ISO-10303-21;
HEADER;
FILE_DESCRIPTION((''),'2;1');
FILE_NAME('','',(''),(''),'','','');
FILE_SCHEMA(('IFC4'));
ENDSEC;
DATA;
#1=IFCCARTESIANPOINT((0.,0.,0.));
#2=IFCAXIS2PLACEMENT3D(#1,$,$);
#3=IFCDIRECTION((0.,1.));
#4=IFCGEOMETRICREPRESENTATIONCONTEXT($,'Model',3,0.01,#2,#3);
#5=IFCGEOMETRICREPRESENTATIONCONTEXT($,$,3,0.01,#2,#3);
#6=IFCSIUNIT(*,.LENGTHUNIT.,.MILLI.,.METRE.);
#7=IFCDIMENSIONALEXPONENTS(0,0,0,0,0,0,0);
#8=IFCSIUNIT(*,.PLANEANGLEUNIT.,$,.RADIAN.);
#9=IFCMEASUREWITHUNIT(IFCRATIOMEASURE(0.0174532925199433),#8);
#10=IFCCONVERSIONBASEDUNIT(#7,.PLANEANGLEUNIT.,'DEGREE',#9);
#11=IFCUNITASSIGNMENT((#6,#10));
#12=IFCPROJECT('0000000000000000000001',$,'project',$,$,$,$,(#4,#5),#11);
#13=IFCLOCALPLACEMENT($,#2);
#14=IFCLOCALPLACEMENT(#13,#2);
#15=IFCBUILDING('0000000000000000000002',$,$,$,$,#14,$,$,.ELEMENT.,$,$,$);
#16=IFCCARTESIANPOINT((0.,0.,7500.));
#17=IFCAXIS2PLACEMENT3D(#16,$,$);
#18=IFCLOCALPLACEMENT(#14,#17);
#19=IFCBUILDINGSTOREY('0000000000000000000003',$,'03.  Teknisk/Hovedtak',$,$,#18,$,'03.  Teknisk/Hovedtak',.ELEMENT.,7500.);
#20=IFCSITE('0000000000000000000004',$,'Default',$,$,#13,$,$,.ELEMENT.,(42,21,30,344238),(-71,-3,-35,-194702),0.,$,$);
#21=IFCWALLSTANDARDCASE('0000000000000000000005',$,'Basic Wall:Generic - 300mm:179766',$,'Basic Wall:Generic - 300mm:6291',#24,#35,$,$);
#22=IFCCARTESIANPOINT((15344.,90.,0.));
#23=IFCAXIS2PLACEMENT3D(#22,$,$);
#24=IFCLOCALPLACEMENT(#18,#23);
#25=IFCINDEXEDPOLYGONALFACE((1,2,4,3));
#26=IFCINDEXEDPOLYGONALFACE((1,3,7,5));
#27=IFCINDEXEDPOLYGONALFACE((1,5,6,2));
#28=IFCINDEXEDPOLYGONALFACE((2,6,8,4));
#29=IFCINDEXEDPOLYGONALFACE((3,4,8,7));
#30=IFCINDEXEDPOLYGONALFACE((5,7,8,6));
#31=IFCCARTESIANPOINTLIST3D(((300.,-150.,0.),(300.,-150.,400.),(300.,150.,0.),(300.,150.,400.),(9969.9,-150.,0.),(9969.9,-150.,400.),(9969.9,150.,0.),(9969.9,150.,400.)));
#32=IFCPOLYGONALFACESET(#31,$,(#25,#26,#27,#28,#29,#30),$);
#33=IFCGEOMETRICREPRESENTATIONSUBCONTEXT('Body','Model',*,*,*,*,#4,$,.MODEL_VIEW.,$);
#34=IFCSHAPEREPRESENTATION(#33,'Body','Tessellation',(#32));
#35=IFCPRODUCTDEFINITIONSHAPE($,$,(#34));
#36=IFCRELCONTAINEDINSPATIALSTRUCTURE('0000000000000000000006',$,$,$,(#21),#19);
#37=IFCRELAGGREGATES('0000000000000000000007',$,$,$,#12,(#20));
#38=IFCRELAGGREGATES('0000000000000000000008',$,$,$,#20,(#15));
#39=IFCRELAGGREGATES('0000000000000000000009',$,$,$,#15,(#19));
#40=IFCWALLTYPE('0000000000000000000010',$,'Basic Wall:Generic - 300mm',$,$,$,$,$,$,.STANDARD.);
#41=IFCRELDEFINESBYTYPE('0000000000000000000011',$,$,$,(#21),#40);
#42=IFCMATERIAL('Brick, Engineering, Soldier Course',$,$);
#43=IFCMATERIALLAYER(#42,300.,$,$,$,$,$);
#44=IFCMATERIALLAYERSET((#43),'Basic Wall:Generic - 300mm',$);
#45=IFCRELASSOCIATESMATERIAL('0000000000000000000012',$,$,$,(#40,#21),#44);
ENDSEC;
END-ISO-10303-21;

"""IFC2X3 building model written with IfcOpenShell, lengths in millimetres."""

from ifc_helpers import new_model, entity, si_unit, converted_unit, direction, frame, frame_2d, origin, place, context, subcontext, project, spatial, rectangle, extrude, clip, halfspace, material, layer, layer_set, layer_usage, type_object, element, save


model = new_model("IFC2X3")

# Units and contexts
model_context = context("Model", 3, precision=0.01, world=origin(), true_north=direction((0.0, 1.0)))
context_of_model = context(None, 3, precision=0.01, world=origin(), true_north=direction((0.0, 1.0)))
body_context = subcontext(model_context, "Body", "Model", "MODEL_VIEW")
ifc_project = project(units=[si_unit("LENGTHUNIT", "METRE", prefix="MILLI"), converted_unit("PLANEANGLEUNIT", "DEGREE", entity("IfcRatioMeasure", 0.0174532925199433), si_unit("PLANEANGLEUNIT", "RADIAN"), dimensions=[0, 0, 0, 0, 0, 0, 0])], contexts=[model_context, context_of_model])

# Site, building, storey
site_placement = place(None, origin())
site = spatial("IfcSite", under=ifc_project, at=site_placement, Name="Default", CompositionType="ELEMENT", RefLatitude=(42, 21, 30, 344238), RefLongitude=(-71, -3, -35, -194702), RefElevation=0.0)
building_placement = place(site_placement, origin())
building = spatial("IfcBuilding", under=site, at=building_placement, CompositionType="ELEMENT")
storey_placement = place(building_placement, frame((0.0, 0.0, 7500.0)))
storey = spatial("IfcBuildingStorey", under=building, at=storey_placement, Name="03.  Teknisk/Hovedtak", LongName="03.  Teknisk/Hovedtak", CompositionType="ELEMENT", Elevation=7500.0)

# Wall
ifc_material_1 = material(Name="Brick, Engineering, Soldier Course")
ifc_layer_1 = layer(ifc_material_1, 300.0)
ifc_layer_set_1 = layer_set([ifc_layer_1], Name="Basic Wall:Generic - 300mm")
ifc_layer_usage_1 = layer_usage(ifc_layer_set_1, "AXIS2", "NEGATIVE", 150.0)
wall_type_1 = type_object("IfcWallType", Name="Basic Wall:Generic - 300mm", PredefinedType="STANDARD", material=ifc_layer_set_1)
wall_1_placement = place(storey_placement, frame((15344.0, 90.0, 0.0)))
element("IfcWallStandardCase", 1, at=wall_1_placement, inside=storey, type_object=wall_type_1, material=ifc_layer_usage_1, Name="Basic Wall:Generic - 300mm:179766", ObjectType="Basic Wall:Generic - 300mm:6291", context=body_context, shape_type="Clipping", body=[
    clip(extrude(rectangle(XDim=9669.9, YDim=300.0, at=frame_2d((5134.9, 0.0), x_axis=(-1.0, 0.0))), origin(), (0.0, 0.0, 1.0), 400.0), halfspace(frame((0.0, 0.0, -3750.0)), True)),
])

save(model, "model.ifc")
